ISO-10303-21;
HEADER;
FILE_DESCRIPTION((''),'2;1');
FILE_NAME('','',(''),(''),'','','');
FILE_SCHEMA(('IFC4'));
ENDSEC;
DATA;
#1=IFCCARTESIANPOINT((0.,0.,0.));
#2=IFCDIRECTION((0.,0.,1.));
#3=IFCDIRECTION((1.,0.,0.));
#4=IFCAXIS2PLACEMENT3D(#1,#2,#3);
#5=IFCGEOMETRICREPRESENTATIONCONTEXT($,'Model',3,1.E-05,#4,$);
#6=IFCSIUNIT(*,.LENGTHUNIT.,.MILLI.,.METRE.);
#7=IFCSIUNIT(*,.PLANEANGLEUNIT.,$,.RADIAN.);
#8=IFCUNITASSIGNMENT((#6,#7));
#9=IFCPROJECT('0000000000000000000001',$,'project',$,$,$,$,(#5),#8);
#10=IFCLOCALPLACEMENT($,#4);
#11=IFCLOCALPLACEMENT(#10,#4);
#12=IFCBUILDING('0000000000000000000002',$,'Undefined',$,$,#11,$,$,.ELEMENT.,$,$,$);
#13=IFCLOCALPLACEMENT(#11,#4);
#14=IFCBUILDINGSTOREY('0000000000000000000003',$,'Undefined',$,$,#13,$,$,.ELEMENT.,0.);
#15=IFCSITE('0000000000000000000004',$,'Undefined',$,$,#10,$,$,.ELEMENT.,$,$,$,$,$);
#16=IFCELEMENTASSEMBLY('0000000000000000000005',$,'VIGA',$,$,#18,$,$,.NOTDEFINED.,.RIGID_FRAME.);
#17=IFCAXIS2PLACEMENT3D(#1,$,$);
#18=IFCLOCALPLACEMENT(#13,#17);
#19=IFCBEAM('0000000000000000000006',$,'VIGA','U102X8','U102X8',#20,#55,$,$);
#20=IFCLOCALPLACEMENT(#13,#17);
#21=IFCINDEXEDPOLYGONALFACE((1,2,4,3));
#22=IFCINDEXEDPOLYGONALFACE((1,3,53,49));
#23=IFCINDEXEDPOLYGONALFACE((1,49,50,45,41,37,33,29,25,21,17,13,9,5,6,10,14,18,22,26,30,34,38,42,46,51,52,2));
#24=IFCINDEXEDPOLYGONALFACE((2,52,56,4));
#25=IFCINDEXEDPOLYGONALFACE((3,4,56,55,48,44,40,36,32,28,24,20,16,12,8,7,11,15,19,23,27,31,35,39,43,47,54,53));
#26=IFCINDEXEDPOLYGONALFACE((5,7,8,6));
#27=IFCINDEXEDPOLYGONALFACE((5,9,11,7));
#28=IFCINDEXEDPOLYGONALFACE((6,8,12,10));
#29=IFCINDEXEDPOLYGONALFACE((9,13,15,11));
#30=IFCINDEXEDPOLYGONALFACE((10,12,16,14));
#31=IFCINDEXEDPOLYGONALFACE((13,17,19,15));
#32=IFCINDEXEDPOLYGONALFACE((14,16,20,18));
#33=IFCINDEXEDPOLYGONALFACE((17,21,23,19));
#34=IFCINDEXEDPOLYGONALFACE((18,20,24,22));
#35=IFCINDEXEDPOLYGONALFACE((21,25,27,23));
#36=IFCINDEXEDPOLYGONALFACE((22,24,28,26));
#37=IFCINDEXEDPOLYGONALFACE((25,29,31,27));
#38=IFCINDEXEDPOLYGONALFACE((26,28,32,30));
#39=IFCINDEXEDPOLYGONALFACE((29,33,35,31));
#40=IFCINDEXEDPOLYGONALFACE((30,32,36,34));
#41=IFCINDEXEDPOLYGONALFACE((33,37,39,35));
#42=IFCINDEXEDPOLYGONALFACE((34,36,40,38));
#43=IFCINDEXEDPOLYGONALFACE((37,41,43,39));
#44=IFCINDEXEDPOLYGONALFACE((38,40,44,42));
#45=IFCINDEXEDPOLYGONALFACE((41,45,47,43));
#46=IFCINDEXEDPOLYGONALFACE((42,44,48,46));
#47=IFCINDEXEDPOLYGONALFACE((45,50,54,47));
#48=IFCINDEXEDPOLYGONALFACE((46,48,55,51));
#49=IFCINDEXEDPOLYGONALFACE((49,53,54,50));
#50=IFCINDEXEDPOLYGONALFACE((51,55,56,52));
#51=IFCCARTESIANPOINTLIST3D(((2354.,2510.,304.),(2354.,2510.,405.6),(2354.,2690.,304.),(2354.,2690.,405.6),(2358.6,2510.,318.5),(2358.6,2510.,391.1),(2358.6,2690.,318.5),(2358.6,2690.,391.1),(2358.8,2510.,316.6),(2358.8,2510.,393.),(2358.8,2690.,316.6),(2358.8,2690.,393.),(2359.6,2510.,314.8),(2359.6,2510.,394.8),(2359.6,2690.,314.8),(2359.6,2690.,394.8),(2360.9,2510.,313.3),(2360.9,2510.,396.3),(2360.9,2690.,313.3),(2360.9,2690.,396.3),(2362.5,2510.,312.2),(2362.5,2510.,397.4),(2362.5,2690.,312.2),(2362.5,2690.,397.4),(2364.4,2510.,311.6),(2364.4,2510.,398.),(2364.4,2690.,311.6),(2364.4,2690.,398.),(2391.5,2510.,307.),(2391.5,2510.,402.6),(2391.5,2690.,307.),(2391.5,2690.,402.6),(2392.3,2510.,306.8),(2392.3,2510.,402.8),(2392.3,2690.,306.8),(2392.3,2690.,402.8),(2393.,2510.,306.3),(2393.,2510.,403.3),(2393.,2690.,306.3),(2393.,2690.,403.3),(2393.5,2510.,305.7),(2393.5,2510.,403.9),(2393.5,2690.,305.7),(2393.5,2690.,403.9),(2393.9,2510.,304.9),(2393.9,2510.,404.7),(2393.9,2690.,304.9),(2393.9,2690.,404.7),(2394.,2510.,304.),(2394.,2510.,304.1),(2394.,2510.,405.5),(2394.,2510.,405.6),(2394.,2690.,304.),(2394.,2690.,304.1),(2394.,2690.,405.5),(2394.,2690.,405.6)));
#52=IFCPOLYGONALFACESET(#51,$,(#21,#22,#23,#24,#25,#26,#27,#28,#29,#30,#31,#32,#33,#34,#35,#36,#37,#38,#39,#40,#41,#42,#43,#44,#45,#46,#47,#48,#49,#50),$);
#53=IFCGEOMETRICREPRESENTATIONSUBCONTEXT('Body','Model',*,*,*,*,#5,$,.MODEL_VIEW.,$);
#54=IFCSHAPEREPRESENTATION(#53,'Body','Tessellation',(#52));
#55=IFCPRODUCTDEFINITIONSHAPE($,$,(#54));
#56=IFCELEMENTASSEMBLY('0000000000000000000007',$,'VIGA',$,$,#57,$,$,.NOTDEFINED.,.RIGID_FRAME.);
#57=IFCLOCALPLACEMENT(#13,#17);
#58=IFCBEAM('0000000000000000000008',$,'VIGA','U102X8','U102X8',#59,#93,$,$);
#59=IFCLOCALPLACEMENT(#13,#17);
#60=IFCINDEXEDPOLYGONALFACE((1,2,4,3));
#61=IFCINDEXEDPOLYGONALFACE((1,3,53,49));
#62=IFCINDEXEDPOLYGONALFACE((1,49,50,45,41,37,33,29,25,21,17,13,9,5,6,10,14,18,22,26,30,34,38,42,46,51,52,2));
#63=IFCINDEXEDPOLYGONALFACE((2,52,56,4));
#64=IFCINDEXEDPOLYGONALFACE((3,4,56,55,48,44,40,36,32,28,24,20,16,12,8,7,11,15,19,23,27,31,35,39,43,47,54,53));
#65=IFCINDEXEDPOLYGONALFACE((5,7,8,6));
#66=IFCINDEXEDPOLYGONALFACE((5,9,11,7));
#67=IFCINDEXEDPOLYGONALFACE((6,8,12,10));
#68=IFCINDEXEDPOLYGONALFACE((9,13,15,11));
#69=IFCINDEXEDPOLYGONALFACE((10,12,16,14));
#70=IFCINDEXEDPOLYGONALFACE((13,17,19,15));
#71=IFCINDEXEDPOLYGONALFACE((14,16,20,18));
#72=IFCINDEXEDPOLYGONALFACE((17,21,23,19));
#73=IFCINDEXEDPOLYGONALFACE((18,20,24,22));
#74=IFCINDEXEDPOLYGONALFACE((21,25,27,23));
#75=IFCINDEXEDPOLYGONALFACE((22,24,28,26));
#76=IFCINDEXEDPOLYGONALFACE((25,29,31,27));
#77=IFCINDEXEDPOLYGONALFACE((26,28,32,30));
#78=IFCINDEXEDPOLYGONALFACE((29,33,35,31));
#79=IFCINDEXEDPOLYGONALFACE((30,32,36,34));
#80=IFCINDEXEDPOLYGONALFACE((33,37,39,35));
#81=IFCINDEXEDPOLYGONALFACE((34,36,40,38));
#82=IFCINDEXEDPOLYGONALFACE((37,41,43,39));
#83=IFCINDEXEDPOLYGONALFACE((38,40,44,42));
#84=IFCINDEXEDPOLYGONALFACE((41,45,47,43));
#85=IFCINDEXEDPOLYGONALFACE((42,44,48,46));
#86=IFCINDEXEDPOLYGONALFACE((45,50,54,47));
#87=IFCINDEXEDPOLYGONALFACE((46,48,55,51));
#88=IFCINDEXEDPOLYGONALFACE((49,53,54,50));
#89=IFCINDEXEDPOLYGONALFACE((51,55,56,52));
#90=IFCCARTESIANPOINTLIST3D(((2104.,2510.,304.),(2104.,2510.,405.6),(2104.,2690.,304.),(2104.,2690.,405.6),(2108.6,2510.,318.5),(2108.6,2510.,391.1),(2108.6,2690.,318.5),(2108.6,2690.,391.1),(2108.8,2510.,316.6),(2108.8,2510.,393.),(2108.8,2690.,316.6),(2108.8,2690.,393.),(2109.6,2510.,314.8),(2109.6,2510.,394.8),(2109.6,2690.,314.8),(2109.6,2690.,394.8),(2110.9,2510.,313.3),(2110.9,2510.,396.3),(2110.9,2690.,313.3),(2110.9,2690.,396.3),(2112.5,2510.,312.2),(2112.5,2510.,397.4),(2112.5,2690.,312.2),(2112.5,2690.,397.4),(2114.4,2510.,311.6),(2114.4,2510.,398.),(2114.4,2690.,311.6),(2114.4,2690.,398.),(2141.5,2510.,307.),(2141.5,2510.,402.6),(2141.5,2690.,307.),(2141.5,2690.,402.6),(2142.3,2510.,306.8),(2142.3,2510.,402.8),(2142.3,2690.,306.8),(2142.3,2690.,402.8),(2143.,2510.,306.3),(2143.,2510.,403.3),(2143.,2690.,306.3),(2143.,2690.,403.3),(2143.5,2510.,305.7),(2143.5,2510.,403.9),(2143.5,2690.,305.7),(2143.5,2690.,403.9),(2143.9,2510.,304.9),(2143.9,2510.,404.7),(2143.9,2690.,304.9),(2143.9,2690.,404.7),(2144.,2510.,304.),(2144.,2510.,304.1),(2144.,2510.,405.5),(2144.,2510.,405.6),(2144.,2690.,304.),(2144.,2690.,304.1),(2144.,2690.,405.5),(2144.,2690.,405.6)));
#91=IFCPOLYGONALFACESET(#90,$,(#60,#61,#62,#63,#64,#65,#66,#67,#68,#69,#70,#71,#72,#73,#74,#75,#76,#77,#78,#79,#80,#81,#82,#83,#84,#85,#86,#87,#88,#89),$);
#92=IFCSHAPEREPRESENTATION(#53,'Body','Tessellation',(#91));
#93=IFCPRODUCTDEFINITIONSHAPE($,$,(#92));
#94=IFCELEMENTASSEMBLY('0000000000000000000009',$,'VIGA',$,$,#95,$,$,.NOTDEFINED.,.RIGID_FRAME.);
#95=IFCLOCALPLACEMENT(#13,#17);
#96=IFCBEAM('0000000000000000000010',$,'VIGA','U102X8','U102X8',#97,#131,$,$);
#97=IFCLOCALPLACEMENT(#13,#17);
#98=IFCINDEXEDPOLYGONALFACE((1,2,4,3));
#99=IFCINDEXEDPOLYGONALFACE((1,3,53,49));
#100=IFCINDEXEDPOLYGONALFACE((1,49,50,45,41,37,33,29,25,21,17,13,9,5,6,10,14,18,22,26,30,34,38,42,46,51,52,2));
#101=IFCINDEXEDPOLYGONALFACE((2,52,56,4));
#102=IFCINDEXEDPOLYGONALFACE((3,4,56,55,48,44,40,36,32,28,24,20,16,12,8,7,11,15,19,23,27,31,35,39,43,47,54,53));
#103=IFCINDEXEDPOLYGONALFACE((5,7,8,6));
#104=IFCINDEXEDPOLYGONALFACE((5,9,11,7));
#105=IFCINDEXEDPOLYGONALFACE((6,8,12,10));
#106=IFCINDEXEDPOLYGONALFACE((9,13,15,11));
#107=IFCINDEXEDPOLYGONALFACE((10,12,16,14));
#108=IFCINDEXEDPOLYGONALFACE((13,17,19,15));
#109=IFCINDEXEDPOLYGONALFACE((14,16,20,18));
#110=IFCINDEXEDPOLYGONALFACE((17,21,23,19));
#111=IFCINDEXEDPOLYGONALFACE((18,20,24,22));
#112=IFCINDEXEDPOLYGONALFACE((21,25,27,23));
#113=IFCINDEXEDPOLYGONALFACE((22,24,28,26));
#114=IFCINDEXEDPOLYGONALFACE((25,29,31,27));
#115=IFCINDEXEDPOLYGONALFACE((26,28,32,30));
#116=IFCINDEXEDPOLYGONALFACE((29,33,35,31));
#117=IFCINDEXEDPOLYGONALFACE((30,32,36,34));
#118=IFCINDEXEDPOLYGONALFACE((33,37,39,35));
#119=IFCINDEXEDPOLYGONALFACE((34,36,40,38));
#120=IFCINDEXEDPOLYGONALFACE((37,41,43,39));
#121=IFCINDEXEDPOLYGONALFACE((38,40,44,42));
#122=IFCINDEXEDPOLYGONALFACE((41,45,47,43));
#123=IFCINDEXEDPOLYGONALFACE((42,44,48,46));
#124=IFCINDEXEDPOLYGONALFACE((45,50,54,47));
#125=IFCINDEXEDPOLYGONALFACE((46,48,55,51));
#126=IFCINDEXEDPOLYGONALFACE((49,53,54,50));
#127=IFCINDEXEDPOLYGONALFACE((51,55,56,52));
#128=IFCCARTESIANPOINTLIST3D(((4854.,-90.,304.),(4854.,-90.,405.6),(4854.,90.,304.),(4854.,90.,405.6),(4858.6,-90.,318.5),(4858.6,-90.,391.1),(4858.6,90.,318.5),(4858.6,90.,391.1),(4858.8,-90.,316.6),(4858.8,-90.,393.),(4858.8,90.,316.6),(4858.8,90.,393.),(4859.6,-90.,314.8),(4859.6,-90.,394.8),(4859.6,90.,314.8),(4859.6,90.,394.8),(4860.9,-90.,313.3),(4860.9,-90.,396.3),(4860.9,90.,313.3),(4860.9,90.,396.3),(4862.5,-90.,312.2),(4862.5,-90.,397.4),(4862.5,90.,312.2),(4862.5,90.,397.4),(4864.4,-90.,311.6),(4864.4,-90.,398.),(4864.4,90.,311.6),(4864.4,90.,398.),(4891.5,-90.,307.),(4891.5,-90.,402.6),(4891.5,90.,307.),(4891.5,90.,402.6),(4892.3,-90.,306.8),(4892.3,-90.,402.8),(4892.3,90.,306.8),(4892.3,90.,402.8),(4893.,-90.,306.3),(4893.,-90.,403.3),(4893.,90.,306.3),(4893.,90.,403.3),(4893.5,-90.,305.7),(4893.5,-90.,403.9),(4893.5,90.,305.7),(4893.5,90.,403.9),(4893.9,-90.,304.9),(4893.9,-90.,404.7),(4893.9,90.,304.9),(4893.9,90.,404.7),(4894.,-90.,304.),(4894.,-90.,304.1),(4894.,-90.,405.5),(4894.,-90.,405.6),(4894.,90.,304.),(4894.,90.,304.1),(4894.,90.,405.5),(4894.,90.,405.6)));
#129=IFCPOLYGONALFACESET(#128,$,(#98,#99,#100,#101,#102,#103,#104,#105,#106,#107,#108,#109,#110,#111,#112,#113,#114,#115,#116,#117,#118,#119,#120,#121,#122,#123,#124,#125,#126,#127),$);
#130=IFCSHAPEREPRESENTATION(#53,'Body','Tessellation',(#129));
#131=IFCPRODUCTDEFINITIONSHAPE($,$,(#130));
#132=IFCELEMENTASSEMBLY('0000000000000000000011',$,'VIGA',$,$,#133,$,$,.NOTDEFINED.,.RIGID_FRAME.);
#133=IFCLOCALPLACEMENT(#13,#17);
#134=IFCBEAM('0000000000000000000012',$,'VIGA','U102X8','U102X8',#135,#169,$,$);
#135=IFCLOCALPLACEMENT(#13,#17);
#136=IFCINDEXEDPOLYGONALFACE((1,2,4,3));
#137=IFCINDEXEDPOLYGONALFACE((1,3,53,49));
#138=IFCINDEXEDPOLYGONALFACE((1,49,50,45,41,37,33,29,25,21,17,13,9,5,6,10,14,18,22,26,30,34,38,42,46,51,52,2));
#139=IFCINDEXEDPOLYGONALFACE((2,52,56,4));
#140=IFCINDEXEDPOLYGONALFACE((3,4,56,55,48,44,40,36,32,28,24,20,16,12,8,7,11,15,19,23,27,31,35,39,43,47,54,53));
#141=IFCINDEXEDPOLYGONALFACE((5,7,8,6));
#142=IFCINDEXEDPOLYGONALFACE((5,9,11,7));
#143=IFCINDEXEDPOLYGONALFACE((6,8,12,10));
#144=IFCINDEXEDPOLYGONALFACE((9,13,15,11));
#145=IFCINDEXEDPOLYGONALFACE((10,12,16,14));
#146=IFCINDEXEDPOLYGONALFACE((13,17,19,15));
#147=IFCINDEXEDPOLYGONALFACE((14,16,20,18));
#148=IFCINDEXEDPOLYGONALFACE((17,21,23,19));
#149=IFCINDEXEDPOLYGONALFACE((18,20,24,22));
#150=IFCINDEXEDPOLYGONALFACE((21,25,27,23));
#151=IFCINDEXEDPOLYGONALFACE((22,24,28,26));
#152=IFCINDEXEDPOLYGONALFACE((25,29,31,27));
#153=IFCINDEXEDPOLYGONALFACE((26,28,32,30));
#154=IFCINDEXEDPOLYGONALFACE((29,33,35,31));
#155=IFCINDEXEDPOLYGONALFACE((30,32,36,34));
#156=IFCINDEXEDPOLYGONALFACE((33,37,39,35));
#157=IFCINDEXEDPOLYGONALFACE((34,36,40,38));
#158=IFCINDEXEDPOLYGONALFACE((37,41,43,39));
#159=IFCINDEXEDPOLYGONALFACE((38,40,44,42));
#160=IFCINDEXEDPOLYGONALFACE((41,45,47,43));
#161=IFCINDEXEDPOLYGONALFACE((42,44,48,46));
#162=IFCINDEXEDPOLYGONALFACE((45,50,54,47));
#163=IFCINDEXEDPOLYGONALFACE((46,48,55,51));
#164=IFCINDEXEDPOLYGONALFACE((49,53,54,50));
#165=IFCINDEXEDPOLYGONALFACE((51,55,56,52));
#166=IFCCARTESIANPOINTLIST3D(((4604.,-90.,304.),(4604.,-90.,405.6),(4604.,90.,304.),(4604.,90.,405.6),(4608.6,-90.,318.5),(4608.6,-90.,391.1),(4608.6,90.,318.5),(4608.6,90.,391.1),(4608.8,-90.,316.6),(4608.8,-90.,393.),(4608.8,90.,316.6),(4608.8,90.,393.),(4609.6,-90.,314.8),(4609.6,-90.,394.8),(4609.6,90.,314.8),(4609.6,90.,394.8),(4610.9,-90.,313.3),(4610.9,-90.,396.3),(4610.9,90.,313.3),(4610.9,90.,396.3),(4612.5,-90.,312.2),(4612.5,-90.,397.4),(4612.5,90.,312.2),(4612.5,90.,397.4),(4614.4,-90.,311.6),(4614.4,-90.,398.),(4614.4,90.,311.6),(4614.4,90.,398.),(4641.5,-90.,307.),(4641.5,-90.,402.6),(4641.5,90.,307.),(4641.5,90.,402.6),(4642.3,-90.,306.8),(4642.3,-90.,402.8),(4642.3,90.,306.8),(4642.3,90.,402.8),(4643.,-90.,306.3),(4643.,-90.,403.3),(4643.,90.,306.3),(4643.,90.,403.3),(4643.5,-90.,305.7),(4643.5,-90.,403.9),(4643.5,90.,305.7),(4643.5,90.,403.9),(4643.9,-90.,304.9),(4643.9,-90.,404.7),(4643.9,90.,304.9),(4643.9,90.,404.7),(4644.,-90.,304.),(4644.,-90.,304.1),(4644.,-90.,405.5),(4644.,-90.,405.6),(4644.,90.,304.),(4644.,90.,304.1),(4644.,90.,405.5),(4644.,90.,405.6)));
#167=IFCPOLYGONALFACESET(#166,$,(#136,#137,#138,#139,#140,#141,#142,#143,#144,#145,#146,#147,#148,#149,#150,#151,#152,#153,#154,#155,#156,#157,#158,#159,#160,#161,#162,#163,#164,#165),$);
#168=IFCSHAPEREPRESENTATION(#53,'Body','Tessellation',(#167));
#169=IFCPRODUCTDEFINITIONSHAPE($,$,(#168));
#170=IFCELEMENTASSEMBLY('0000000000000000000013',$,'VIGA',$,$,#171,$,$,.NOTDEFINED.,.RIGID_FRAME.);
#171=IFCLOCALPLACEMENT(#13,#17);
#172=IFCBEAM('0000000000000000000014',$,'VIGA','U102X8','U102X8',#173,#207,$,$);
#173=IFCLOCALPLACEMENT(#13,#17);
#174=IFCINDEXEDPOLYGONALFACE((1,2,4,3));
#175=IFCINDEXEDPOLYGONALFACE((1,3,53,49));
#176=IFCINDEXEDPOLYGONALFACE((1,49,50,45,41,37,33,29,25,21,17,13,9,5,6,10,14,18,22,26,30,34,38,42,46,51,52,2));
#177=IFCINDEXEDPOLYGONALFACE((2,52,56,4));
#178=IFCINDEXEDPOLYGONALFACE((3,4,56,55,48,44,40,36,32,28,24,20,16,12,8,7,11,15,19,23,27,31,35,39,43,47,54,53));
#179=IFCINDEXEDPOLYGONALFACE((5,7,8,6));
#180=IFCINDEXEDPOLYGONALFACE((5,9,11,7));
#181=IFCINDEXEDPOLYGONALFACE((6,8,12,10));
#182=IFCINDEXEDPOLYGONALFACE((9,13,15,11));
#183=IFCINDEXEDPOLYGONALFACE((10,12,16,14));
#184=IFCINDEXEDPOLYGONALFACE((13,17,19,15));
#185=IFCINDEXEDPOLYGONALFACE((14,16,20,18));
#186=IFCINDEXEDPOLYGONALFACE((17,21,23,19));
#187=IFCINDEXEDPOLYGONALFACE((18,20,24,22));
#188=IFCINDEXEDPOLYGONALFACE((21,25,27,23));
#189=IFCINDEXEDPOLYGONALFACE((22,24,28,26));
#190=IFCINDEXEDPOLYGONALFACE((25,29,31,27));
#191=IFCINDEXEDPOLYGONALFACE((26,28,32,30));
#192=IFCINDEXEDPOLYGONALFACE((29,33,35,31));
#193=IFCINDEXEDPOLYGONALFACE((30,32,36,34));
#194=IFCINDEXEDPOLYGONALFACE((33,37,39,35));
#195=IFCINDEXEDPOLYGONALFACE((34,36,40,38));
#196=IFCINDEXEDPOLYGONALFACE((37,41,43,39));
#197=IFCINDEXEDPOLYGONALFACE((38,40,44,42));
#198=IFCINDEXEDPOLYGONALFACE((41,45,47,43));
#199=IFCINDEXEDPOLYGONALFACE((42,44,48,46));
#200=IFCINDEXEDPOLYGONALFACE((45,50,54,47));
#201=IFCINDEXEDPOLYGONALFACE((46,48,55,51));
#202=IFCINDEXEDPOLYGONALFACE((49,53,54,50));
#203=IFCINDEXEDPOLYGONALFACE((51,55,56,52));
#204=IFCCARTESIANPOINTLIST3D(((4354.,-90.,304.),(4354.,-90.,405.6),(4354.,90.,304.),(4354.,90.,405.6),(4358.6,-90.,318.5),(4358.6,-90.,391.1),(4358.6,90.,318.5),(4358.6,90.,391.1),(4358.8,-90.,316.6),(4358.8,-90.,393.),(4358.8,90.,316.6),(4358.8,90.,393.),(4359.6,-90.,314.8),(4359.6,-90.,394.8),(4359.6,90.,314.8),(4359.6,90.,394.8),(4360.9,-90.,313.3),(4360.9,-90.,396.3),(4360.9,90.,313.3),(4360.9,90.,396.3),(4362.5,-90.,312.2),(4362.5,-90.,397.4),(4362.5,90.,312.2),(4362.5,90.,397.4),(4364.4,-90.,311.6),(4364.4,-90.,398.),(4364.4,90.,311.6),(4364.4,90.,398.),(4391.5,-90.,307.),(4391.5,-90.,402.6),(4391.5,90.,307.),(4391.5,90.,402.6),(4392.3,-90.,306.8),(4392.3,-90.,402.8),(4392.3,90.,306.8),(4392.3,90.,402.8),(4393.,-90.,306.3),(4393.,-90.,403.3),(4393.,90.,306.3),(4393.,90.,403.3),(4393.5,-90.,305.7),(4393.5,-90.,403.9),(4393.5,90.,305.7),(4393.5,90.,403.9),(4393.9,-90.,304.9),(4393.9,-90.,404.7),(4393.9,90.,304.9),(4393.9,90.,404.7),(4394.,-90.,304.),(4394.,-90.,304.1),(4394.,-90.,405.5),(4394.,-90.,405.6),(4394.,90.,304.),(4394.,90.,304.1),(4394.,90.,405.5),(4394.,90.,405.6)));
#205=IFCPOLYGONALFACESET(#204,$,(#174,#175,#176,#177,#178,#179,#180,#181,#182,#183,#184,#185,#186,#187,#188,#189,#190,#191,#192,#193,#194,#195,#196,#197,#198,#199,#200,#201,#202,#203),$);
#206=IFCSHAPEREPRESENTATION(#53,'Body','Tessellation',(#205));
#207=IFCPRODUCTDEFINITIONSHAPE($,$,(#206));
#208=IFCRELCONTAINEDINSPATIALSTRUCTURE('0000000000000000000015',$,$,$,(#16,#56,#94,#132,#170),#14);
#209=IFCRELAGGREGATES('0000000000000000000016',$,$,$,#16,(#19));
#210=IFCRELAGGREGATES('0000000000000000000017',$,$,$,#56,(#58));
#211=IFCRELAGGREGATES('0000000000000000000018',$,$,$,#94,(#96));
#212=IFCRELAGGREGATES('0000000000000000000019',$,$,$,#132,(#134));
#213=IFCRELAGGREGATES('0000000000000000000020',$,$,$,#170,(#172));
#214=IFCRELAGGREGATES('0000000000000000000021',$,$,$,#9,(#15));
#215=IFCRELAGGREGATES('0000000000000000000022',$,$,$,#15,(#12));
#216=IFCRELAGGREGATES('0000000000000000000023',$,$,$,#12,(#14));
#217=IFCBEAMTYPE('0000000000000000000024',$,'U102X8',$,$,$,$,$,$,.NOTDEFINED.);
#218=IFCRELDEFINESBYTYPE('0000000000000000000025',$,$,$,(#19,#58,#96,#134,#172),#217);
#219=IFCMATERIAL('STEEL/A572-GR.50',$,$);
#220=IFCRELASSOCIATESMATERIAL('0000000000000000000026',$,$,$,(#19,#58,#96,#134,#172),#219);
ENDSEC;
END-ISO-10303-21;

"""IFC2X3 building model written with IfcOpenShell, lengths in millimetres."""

from ifc_helpers import new_model, si_unit, frame, origin_with_axes, origin_2d_with_axis, place, context, subcontext, project, spatial, u_section, extrude, material, type_object, element, aggregate, save


model = new_model("IFC2X3")

# Units and contexts
model_context = context("Model", 3, precision=1e-05, world=origin_with_axes())
body_context = subcontext(model_context, "Body", "Model", "MODEL_VIEW")
ifc_project = project(units=[si_unit("LENGTHUNIT", "METRE", prefix="MILLI"), si_unit("PLANEANGLEUNIT", "RADIAN")], contexts=[model_context])

# Site, building, storey
site_placement = place(None, origin_with_axes())
site = spatial("IfcSite", under=ifc_project, at=site_placement, Name="Undefined", CompositionType="ELEMENT")
building_placement = place(site_placement, origin_with_axes())
building = spatial("IfcBuilding", under=site, at=building_placement, Name="Undefined", CompositionType="ELEMENT")
storey_placement = place(building_placement, origin_with_axes())
storey = spatial("IfcBuildingStorey", under=building, at=storey_placement, Name="Undefined", CompositionType="ELEMENT", Elevation=0.0)

# Element assemblies, beams
ifc_material_1 = material(Name="STEEL/A572-GR.50")
beam_type = type_object("IfcBeamType", Name="U102X8", PredefinedType="NOTDEFINED")
assembly_1_placement = place(storey_placement, origin_with_axes())
assembly_1 = element("IfcElementAssembly", 1, at=assembly_1_placement, inside=storey, Name="VIGA", AssemblyPlace="NOTDEFINED", PredefinedType="RIGID_FRAME")
beam_1_placement = place(assembly_1_placement, frame((2374.0, 2510.0, 354.8), z_axis=(0.0, 0.0, 1.0), x_axis=(0.0, 1.0, 0.0)))
beam_1 = element("IfcBeam", 2, at=beam_1_placement, type_object=beam_type, material=ifc_material_1, Name="VIGA", Description="U102X8", ObjectType="U102X8", context=body_context, shape_type="SweptSolid", body=[
    extrude(u_section(Depth=101.6, FlangeWidth=40.0, WebThickness=4.6, FlangeThickness=6.0, FilletRadius=7.0, EdgeRadius=3.0, FlangeSlope=0.16839, at=origin_2d_with_axis()), frame((180.0, 0.0, 0.0), z_axis=(-1.0, 0.0, 0.0), x_axis=(0.0, -1.0, 0.0)), (0.0, 0.0, 1.0), 180.0),
])
aggregate(assembly_1, [beam_1])
assembly_2_placement = place(storey_placement, origin_with_axes())
assembly_2 = element("IfcElementAssembly", 3, at=assembly_2_placement, inside=storey, Name="VIGA", AssemblyPlace="NOTDEFINED", PredefinedType="RIGID_FRAME")
beam_2_placement = place(assembly_2_placement, frame((2124.0, 2510.0, 354.8), z_axis=(0.0, 0.0, 1.0), x_axis=(0.0, 1.0, 0.0)))
beam_2 = element("IfcBeam", 4, at=beam_2_placement, type_object=beam_type, material=ifc_material_1, Name="VIGA", Description="U102X8", ObjectType="U102X8", context=body_context, shape_type="SweptSolid", body=[
    extrude(u_section(Depth=101.6, FlangeWidth=40.0, WebThickness=4.6, FlangeThickness=6.0, FilletRadius=7.0, EdgeRadius=3.0, FlangeSlope=0.16839, at=origin_2d_with_axis()), frame((180.0, 0.0, 0.0), z_axis=(-1.0, 0.0, 0.0), x_axis=(0.0, -1.0, 0.0)), (0.0, 0.0, 1.0), 180.0),
])
aggregate(assembly_2, [beam_2])
assembly_3_placement = place(storey_placement, origin_with_axes())
assembly_3 = element("IfcElementAssembly", 5, at=assembly_3_placement, inside=storey, Name="VIGA", AssemblyPlace="NOTDEFINED", PredefinedType="RIGID_FRAME")
beam_3_placement = place(assembly_3_placement, frame((4874.0, -90.0, 354.8), z_axis=(0.0, 0.0, 1.0), x_axis=(0.0, 1.0, 0.0)))
beam_3 = element("IfcBeam", 6, at=beam_3_placement, type_object=beam_type, material=ifc_material_1, Name="VIGA", Description="U102X8", ObjectType="U102X8", context=body_context, shape_type="SweptSolid", body=[
    extrude(u_section(Depth=101.6, FlangeWidth=40.0, WebThickness=4.6, FlangeThickness=6.0, FilletRadius=7.0, EdgeRadius=3.0, FlangeSlope=0.16839, at=origin_2d_with_axis()), frame((180.0, 0.0, 0.0), z_axis=(-1.0, 0.0, 0.0), x_axis=(0.0, -1.0, 0.0)), (0.0, 0.0, 1.0), 180.0),
])
aggregate(assembly_3, [beam_3])
assembly_4_placement = place(storey_placement, origin_with_axes())
assembly_4 = element("IfcElementAssembly", 7, at=assembly_4_placement, inside=storey, Name="VIGA", AssemblyPlace="NOTDEFINED", PredefinedType="RIGID_FRAME")
beam_4_placement = place(assembly_4_placement, frame((4624.0, -90.0, 354.8), z_axis=(0.0, 0.0, 1.0), x_axis=(0.0, 1.0, 0.0)))
beam_4 = element("IfcBeam", 8, at=beam_4_placement, type_object=beam_type, material=ifc_material_1, Name="VIGA", Description="U102X8", ObjectType="U102X8", context=body_context, shape_type="SweptSolid", body=[
    extrude(u_section(Depth=101.6, FlangeWidth=40.0, WebThickness=4.6, FlangeThickness=6.0, FilletRadius=7.0, EdgeRadius=3.0, FlangeSlope=0.16839, at=origin_2d_with_axis()), frame((180.0, 0.0, 0.0), z_axis=(-1.0, 0.0, 0.0), x_axis=(0.0, -1.0, 0.0)), (0.0, 0.0, 1.0), 180.0),
])
aggregate(assembly_4, [beam_4])
assembly_5_placement = place(storey_placement, origin_with_axes())
assembly_5 = element("IfcElementAssembly", 9, at=assembly_5_placement, inside=storey, Name="VIGA", AssemblyPlace="NOTDEFINED", PredefinedType="RIGID_FRAME")
beam_5_placement = place(assembly_5_placement, frame((4374.0, -90.0, 354.8), z_axis=(0.0, 0.0, 1.0), x_axis=(0.0, 1.0, 0.0)))
beam_5 = element("IfcBeam", 10, at=beam_5_placement, type_object=beam_type, material=ifc_material_1, Name="VIGA", Description="U102X8", ObjectType="U102X8", context=body_context, shape_type="SweptSolid", body=[
    extrude(u_section(Depth=101.6, FlangeWidth=40.0, WebThickness=4.6, FlangeThickness=6.0, FilletRadius=7.0, EdgeRadius=3.0, FlangeSlope=0.16839, at=origin_2d_with_axis()), frame((180.0, 0.0, 0.0), z_axis=(-1.0, 0.0, 0.0), x_axis=(0.0, -1.0, 0.0)), (0.0, 0.0, 1.0), 180.0),
])
aggregate(assembly_5, [beam_5])

save(model, "model.ifc")
